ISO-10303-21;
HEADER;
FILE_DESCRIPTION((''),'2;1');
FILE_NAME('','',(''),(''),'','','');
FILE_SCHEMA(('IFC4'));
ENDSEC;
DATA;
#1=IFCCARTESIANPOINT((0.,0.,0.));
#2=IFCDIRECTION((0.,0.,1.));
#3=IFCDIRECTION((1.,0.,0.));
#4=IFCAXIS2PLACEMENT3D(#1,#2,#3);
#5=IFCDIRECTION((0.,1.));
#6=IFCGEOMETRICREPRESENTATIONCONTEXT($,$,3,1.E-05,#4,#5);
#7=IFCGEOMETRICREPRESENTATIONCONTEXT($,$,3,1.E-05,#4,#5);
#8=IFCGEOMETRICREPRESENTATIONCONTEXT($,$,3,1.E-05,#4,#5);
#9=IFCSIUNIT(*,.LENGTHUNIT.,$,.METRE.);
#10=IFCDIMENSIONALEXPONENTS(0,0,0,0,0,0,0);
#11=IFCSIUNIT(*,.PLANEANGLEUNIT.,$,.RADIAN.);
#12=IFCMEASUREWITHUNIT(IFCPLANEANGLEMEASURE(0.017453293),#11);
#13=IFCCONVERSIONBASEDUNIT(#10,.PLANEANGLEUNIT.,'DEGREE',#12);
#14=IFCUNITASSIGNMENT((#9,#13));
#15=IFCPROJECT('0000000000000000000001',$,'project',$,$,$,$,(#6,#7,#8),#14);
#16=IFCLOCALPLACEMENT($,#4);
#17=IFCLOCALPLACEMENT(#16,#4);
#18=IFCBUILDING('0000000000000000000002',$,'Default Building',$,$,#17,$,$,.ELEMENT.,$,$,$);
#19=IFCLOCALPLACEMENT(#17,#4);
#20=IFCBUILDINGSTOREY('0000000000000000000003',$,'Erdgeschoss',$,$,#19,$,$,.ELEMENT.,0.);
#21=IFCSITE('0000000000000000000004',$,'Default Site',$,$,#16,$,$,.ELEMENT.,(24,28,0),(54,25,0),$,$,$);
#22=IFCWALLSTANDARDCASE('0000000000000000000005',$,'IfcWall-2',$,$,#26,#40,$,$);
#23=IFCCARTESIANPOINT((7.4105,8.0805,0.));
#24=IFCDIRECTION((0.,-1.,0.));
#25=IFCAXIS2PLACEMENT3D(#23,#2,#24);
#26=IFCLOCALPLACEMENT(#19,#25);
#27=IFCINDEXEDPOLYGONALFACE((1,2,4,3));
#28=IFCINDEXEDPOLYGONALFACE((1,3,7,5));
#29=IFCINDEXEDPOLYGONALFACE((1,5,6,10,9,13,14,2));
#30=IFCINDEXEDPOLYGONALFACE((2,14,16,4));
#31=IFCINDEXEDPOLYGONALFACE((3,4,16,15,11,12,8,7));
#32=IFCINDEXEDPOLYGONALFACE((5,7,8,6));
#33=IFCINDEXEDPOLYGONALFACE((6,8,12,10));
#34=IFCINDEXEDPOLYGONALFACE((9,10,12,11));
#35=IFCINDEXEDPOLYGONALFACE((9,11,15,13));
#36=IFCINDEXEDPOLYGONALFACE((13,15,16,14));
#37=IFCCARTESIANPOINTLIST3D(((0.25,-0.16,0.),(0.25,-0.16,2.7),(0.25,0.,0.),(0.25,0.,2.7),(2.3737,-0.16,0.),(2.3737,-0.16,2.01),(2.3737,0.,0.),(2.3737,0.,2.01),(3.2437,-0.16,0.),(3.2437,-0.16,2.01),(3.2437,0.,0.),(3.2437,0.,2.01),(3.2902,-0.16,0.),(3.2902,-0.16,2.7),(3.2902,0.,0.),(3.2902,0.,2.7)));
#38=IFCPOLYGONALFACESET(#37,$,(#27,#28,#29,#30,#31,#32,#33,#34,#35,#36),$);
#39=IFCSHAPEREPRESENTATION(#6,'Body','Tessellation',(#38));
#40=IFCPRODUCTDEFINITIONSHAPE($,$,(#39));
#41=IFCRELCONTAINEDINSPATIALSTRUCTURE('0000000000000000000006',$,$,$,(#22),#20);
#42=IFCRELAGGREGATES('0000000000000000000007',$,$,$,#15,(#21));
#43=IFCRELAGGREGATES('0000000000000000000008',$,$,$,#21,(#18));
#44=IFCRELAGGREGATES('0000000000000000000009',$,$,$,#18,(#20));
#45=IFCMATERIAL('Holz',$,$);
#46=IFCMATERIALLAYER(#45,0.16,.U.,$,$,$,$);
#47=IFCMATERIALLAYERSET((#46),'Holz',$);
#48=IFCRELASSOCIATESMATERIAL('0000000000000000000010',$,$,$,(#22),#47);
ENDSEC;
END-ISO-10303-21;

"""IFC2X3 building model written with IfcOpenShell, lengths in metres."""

from ifc_helpers import new_model, entity, si_unit, converted_unit, direction, frame, frame_2d, origin_with_axes, place, context, project, spatial, polyline, rectangle, outline, extrude, material, layer, layer_set, layer_usage, element, save


model = new_model("IFC2X3")

# Units and contexts
context_of_model_1 = context(None, 3, precision=1e-05, world=origin_with_axes(), true_north=direction((0.0, 1.0)))
context_of_model_2 = context(None, 3, precision=1e-05, world=origin_with_axes(), true_north=direction((0.0, 1.0)))
context_of_model_3 = context(None, 3, precision=1e-05, world=origin_with_axes(), true_north=direction((0.0, 1.0)))
ifc_project = project(units=[si_unit("LENGTHUNIT", "METRE"), converted_unit("PLANEANGLEUNIT", "DEGREE", entity("IfcPlaneAngleMeasure", 0.017453293), si_unit("PLANEANGLEUNIT", "RADIAN"), dimensions=[0, 0, 0, 0, 0, 0, 0])], contexts=[context_of_model_1, context_of_model_2, context_of_model_3])

# Site, building, storey
site_placement = place(None, origin_with_axes())
site = spatial("IfcSite", under=ifc_project, at=site_placement, Name="Default Site", CompositionType="ELEMENT", RefLatitude=(24, 28, 0), RefLongitude=(54, 25, 0))
building_placement = place(site_placement, origin_with_axes())
building = spatial("IfcBuilding", under=site, at=building_placement, Name="Default Building", CompositionType="ELEMENT")
storey_placement = place(building_placement, origin_with_axes())
storey = spatial("IfcBuildingStorey", under=building, at=storey_placement, Name="Erdgeschoss", CompositionType="ELEMENT", Elevation=0.0)

# Shared definitions
ifc_material_1 = material(Name="Holz")

# Wall, opening
ifc_layer_1 = layer(ifc_material_1, 0.16, ventilated="UNKNOWN")
ifc_layer_set_1 = layer_set([ifc_layer_1], Name="Holz")
ifc_layer_usage_1 = layer_usage(ifc_layer_set_1, "AXIS2", "NEGATIVE", 0.0)
wall_1_placement = place(storey_placement, frame((7.4105, 8.0805, 0.0), z_axis=(0.0, 0.0, 1.0), x_axis=(0.0, -1.0, 0.0)))
wall_1 = element("IfcWallStandardCase", 1, at=wall_1_placement, inside=storey, material=ifc_layer_usage_1, Name="IfcWall-2", context=context_of_model_1, shape_type="SweptSolid", body=[
    extrude(outline(polyline([(0.25, -0.16), (3.2902, -0.16), (3.2902, 0.0), (0.25, 0.0), (0.25, -0.16)])), origin_with_axes(), (0.0, 0.0, 1.0), 2.7),
])
opening_1_placement = place(wall_1_placement, frame((2.8087, -0.16, 0.0), z_axis=(0.0, 0.0, 1.0), x_axis=(1.0, 0.0, 0.0)))
element("IfcOpeningElement", 2, at=opening_1_placement, cuts=wall_1, context=context_of_model_1, shape_type="SweptSolid", body=[
    extrude(rectangle(XDim=2.01, YDim=0.87, at=frame_2d((0.0, 1.005), x_axis=(0.0, -1.0))), frame((0.0, 0.0, 0.0), z_axis=(0.0, 1.0, 0.0), x_axis=(-1.0, 0.0, 0.0)), (0.0, 0.0, 1.0), 0.16),
])

save(model, "model.ifc")
